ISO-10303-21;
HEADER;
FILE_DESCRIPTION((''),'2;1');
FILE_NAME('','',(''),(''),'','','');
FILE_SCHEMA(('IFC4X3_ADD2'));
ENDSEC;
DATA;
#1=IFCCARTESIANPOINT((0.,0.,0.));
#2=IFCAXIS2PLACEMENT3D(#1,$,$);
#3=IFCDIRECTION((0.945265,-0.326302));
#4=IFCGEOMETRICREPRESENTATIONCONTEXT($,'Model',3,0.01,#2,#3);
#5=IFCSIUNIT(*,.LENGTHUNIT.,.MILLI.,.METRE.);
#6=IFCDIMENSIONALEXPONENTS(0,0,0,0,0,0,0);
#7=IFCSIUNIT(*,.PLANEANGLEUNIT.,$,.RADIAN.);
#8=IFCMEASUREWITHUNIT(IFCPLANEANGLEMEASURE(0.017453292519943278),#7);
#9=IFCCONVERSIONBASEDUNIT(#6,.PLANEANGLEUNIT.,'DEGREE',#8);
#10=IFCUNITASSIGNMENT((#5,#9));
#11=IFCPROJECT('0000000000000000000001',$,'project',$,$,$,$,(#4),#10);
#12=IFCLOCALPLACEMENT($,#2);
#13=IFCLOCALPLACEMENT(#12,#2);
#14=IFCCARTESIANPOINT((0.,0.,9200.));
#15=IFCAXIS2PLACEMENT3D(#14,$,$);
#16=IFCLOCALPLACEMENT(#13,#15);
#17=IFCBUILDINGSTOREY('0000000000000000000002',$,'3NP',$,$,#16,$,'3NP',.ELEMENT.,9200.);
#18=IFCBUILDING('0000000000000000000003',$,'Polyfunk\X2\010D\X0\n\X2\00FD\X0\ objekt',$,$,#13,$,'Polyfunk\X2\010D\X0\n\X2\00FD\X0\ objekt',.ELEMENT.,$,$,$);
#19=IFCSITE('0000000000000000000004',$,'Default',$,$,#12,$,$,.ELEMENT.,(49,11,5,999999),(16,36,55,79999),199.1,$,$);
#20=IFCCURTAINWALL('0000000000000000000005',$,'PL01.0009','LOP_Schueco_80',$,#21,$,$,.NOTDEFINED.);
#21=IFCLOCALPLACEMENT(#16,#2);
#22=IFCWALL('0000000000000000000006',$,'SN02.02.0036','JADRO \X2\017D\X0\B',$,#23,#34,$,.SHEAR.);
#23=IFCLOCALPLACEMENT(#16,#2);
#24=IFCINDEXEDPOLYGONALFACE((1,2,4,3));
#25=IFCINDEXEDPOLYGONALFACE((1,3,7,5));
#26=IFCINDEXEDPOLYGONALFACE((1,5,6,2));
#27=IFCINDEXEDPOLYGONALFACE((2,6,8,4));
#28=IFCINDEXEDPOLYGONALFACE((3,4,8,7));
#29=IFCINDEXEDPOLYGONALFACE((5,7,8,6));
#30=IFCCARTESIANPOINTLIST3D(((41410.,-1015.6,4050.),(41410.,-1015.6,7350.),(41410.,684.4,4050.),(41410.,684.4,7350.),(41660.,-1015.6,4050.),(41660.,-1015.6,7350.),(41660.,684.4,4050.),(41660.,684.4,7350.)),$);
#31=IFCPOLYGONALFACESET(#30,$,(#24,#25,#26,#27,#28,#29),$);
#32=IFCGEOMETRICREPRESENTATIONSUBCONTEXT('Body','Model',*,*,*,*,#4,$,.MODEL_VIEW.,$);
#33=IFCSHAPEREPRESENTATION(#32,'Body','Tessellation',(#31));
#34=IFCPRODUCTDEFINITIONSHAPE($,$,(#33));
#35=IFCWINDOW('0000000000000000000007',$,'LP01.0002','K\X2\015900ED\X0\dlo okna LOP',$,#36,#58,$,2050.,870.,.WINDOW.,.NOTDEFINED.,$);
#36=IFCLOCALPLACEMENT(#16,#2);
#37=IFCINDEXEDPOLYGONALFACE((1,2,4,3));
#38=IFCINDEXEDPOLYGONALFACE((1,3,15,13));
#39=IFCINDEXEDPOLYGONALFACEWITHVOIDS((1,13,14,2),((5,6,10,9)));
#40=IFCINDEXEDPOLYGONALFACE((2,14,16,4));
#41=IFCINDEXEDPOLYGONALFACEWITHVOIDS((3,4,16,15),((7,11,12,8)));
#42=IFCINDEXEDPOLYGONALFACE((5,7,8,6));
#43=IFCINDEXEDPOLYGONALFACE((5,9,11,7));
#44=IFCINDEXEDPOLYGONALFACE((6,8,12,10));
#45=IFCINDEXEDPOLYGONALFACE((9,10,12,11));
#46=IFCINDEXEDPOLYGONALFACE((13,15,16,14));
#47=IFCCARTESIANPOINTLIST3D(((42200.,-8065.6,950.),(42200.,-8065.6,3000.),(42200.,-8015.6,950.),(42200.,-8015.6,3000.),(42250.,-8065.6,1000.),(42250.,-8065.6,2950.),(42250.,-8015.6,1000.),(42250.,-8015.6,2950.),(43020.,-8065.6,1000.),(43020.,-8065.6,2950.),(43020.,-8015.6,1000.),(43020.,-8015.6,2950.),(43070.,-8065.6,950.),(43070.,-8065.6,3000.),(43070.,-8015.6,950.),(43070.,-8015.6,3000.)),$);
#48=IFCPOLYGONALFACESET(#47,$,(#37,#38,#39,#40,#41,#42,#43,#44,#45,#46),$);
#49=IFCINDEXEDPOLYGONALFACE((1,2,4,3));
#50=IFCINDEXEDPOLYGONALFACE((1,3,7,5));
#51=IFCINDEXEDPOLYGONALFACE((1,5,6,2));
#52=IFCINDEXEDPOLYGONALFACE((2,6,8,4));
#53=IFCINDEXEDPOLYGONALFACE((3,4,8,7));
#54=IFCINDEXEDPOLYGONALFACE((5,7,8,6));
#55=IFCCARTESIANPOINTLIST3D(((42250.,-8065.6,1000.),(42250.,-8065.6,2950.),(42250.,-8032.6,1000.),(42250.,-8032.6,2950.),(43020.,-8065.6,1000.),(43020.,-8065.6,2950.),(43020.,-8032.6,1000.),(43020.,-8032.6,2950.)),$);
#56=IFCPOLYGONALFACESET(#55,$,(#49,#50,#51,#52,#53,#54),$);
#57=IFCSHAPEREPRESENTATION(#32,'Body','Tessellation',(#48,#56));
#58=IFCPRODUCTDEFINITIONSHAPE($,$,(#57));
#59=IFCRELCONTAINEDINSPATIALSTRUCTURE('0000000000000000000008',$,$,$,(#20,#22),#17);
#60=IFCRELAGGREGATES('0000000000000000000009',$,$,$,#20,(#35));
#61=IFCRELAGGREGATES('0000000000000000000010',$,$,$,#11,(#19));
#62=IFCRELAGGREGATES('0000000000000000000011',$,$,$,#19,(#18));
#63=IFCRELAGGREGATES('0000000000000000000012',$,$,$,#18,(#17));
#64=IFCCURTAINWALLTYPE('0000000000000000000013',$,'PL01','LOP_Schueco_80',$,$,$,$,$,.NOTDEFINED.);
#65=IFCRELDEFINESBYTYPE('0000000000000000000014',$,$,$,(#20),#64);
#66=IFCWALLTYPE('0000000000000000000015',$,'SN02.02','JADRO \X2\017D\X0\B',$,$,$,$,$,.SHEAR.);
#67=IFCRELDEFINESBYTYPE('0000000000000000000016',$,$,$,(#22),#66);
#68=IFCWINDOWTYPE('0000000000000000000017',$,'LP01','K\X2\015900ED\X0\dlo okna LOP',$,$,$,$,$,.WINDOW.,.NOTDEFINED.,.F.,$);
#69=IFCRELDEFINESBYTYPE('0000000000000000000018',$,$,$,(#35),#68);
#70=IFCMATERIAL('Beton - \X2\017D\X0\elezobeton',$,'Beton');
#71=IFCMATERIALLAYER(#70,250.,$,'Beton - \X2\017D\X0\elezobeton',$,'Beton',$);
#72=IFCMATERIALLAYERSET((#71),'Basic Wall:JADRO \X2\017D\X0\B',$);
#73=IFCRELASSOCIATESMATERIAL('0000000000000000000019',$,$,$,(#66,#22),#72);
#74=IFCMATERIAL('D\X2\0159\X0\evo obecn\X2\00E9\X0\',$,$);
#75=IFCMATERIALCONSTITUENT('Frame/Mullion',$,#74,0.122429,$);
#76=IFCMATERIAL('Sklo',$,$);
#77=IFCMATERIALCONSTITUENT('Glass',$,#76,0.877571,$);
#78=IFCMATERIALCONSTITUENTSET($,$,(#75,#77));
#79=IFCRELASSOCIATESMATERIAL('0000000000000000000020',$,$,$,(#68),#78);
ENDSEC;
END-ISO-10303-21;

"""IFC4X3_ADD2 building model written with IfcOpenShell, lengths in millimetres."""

from ifc_helpers import new_model, entity, si_unit, converted_unit, direction, frame, frame_2d, origin, place, context, subcontext, project, spatial, polyline, rectangle, outline, extrude, clip, bounded_halfspace, source, transform, mapped, material, layer, layer_set, constituent, constituent_set, type_object, type_shapes, element, aggregate, save


model = new_model("IFC4X3_ADD2")

# Units and contexts
model_context = context("Model", 3, precision=0.01, world=origin(), true_north=direction((0.945265, -0.326302)))
body_context = subcontext(model_context, "Body", "Model", "MODEL_VIEW")
ifc_project = project(units=[si_unit("LENGTHUNIT", "METRE", prefix="MILLI"), converted_unit("PLANEANGLEUNIT", "DEGREE", entity("IfcPlaneAngleMeasure", 0.017453292519943278), si_unit("PLANEANGLEUNIT", "RADIAN"), dimensions=[0, 0, 0, 0, 0, 0, 0])], contexts=[model_context])

# Site, building, storey
site_placement = place(None, origin())
site = spatial("IfcSite", under=ifc_project, at=site_placement, Name="Default", CompositionType="ELEMENT", RefLatitude=(49, 11, 5, 999999), RefLongitude=(16, 36, 55, 79999), RefElevation=199.1)
building_placement = place(site_placement, origin())
building = spatial("IfcBuilding", under=site, at=building_placement, Name="Polyfunkčný objekt", LongName="Polyfunkčný objekt", CompositionType="ELEMENT")
storey_placement = place(building_placement, frame((0.0, 0.0, 9200.0)))
storey = spatial("IfcBuildingStorey", under=building, at=storey_placement, Name="3NP", LongName="3NP", CompositionType="ELEMENT", Elevation=9200.0)

# Curtain wall
curtain_wall_type = type_object("IfcCurtainWallType", Name="PL01", Description="LOP_Schueco_80", PredefinedType="NOTDEFINED")
curtain_wall_placement = place(storey_placement, frame((0.0, 0.0, -9200.0)))
curtain_wall = element("IfcCurtainWall", 1, at=curtain_wall_placement, inside=storey, type_object=curtain_wall_type, Name="PL01.0009", Description="LOP_Schueco_80", PredefinedType="NOTDEFINED")
ifc_material_1 = material(Name="Sklo")

# Wall
ifc_material_2 = material(Name="Beton - Železobeton", Category="Beton")
ifc_layer_1 = layer(ifc_material_2, 250.0, Name="Beton - Železobeton", Category="Beton")
ifc_layer_set_1 = layer_set([ifc_layer_1], Name="Basic Wall:JADRO ŽB")
wall_type = type_object("IfcWallType", Name="SN02.02", Description="JADRO ŽB", PredefinedType="SHEAR", material=ifc_layer_set_1)
wall_1_placement = place(storey_placement, frame((41535.0, 684.4, 4050.0), z_axis=(0.0, 0.0, 1.0), x_axis=(0.0, -1.0, 0.0)))
element("IfcWall", 2, at=wall_1_placement, inside=storey, type_object=wall_type, material=ifc_layer_set_1, Name="SN02.02.0036", Description="JADRO ŽB", PredefinedType="SHEAR", context=body_context, shape_type="Clipping", body=[
    clip(clip(extrude(rectangle(XDim=1700.0, YDim=250.0, at=frame_2d((850.0, 0.0), x_axis=(-1.0, 0.0))), origin(), (0.0, 0.0, 1.0), 3300.0), bounded_halfspace(frame((1700.0, -125.0, 0.0), z_axis=(0.0, 0.0, 1.0), x_axis=(0.0, -1.0, 0.0)), True, frame((1700.0, -125.0, 0.0)), polyline([(0.0, 0.0), (0.0, 250.0), (-1700.0, 250.0), (-1700.0, 0.0), (0.0, 0.0)]))), bounded_halfspace(frame((0.0, -125.0, 3300.0), z_axis=(0.0, 0.0, -1.0), x_axis=(1.0, 0.0, 0.0)), True, frame((0.0, -125.0, 3300.0)), polyline([(0.0, 0.0), (1700.0, 0.0), (1700.0, 250.0), (0.0, 250.0), (0.0, 0.0)]))),
])

# Window
ifc_material_3 = material(Name="Dřevo obecné")
ifc_constituent_1 = constituent(ifc_material_3, Name="Frame/Mullion", fraction=0.122429)
ifc_constituent_2 = constituent(ifc_material_1, Name="Glass", fraction=0.877571)
ifc_constituent_set = constituent_set(constituents=[ifc_constituent_1, ifc_constituent_2])
window_type = type_object("IfcWindowType", Name="LP01", Description="Křídlo okna LOP", ParameterTakesPrecedence=False, PartitioningType="NOTDEFINED", PredefinedType="WINDOW", material=ifc_constituent_set)
shared_shape_1 = source(origin(), body_context, "Body", "SweptSolid", [
    extrude(outline(polyline([(-1025.0, -435.0), (1025.0, -435.0), (1025.0, 435.0), (-1025.0, 435.0), (-1025.0, -435.0)]), holes=[polyline([(-975.0, -385.0), (-975.0, 385.0), (975.0, 385.0), (975.0, -385.0), (-975.0, -385.0)])]), frame((0.0, 50.0, 1025.0), z_axis=(0.0, -1.0, 0.0), x_axis=(0.0, 0.0, -1.0)), (0.0, 0.0, 1.0), 50.0),
    extrude(rectangle(XDim=770.0, YDim=33.0, at=frame_2d((0.0, 0.0), x_axis=(1.0, 0.0))), frame((0.0, 33.5, 50.0), z_axis=(0.0, 0.0, 1.0), x_axis=(-1.0, 0.0, 0.0)), (0.0, 0.0, 1.0), 1950.0),
])
type_shapes(window_type, [shared_shape_1])
window_placement = place(curtain_wall_placement, frame((42635.0, -8015.6, 10150.0), z_axis=(0.0, 0.0, 1.0), x_axis=(-1.0, 0.0, 0.0)))
window = element("IfcWindow", 3, at=window_placement, type_object=window_type, Name="LP01.0002", Description="Křídlo okna LOP", OverallHeight=2050.0, OverallWidth=870.0, PartitioningType="NOTDEFINED", PredefinedType="WINDOW", context=body_context, shape_type="MappedRepresentation", body=[
    mapped(shared_shape_1, transform((0.0, 0.0, 0.0), scale=1.0)),
])
aggregate(curtain_wall, [window])

save(model, "model.ifc")
